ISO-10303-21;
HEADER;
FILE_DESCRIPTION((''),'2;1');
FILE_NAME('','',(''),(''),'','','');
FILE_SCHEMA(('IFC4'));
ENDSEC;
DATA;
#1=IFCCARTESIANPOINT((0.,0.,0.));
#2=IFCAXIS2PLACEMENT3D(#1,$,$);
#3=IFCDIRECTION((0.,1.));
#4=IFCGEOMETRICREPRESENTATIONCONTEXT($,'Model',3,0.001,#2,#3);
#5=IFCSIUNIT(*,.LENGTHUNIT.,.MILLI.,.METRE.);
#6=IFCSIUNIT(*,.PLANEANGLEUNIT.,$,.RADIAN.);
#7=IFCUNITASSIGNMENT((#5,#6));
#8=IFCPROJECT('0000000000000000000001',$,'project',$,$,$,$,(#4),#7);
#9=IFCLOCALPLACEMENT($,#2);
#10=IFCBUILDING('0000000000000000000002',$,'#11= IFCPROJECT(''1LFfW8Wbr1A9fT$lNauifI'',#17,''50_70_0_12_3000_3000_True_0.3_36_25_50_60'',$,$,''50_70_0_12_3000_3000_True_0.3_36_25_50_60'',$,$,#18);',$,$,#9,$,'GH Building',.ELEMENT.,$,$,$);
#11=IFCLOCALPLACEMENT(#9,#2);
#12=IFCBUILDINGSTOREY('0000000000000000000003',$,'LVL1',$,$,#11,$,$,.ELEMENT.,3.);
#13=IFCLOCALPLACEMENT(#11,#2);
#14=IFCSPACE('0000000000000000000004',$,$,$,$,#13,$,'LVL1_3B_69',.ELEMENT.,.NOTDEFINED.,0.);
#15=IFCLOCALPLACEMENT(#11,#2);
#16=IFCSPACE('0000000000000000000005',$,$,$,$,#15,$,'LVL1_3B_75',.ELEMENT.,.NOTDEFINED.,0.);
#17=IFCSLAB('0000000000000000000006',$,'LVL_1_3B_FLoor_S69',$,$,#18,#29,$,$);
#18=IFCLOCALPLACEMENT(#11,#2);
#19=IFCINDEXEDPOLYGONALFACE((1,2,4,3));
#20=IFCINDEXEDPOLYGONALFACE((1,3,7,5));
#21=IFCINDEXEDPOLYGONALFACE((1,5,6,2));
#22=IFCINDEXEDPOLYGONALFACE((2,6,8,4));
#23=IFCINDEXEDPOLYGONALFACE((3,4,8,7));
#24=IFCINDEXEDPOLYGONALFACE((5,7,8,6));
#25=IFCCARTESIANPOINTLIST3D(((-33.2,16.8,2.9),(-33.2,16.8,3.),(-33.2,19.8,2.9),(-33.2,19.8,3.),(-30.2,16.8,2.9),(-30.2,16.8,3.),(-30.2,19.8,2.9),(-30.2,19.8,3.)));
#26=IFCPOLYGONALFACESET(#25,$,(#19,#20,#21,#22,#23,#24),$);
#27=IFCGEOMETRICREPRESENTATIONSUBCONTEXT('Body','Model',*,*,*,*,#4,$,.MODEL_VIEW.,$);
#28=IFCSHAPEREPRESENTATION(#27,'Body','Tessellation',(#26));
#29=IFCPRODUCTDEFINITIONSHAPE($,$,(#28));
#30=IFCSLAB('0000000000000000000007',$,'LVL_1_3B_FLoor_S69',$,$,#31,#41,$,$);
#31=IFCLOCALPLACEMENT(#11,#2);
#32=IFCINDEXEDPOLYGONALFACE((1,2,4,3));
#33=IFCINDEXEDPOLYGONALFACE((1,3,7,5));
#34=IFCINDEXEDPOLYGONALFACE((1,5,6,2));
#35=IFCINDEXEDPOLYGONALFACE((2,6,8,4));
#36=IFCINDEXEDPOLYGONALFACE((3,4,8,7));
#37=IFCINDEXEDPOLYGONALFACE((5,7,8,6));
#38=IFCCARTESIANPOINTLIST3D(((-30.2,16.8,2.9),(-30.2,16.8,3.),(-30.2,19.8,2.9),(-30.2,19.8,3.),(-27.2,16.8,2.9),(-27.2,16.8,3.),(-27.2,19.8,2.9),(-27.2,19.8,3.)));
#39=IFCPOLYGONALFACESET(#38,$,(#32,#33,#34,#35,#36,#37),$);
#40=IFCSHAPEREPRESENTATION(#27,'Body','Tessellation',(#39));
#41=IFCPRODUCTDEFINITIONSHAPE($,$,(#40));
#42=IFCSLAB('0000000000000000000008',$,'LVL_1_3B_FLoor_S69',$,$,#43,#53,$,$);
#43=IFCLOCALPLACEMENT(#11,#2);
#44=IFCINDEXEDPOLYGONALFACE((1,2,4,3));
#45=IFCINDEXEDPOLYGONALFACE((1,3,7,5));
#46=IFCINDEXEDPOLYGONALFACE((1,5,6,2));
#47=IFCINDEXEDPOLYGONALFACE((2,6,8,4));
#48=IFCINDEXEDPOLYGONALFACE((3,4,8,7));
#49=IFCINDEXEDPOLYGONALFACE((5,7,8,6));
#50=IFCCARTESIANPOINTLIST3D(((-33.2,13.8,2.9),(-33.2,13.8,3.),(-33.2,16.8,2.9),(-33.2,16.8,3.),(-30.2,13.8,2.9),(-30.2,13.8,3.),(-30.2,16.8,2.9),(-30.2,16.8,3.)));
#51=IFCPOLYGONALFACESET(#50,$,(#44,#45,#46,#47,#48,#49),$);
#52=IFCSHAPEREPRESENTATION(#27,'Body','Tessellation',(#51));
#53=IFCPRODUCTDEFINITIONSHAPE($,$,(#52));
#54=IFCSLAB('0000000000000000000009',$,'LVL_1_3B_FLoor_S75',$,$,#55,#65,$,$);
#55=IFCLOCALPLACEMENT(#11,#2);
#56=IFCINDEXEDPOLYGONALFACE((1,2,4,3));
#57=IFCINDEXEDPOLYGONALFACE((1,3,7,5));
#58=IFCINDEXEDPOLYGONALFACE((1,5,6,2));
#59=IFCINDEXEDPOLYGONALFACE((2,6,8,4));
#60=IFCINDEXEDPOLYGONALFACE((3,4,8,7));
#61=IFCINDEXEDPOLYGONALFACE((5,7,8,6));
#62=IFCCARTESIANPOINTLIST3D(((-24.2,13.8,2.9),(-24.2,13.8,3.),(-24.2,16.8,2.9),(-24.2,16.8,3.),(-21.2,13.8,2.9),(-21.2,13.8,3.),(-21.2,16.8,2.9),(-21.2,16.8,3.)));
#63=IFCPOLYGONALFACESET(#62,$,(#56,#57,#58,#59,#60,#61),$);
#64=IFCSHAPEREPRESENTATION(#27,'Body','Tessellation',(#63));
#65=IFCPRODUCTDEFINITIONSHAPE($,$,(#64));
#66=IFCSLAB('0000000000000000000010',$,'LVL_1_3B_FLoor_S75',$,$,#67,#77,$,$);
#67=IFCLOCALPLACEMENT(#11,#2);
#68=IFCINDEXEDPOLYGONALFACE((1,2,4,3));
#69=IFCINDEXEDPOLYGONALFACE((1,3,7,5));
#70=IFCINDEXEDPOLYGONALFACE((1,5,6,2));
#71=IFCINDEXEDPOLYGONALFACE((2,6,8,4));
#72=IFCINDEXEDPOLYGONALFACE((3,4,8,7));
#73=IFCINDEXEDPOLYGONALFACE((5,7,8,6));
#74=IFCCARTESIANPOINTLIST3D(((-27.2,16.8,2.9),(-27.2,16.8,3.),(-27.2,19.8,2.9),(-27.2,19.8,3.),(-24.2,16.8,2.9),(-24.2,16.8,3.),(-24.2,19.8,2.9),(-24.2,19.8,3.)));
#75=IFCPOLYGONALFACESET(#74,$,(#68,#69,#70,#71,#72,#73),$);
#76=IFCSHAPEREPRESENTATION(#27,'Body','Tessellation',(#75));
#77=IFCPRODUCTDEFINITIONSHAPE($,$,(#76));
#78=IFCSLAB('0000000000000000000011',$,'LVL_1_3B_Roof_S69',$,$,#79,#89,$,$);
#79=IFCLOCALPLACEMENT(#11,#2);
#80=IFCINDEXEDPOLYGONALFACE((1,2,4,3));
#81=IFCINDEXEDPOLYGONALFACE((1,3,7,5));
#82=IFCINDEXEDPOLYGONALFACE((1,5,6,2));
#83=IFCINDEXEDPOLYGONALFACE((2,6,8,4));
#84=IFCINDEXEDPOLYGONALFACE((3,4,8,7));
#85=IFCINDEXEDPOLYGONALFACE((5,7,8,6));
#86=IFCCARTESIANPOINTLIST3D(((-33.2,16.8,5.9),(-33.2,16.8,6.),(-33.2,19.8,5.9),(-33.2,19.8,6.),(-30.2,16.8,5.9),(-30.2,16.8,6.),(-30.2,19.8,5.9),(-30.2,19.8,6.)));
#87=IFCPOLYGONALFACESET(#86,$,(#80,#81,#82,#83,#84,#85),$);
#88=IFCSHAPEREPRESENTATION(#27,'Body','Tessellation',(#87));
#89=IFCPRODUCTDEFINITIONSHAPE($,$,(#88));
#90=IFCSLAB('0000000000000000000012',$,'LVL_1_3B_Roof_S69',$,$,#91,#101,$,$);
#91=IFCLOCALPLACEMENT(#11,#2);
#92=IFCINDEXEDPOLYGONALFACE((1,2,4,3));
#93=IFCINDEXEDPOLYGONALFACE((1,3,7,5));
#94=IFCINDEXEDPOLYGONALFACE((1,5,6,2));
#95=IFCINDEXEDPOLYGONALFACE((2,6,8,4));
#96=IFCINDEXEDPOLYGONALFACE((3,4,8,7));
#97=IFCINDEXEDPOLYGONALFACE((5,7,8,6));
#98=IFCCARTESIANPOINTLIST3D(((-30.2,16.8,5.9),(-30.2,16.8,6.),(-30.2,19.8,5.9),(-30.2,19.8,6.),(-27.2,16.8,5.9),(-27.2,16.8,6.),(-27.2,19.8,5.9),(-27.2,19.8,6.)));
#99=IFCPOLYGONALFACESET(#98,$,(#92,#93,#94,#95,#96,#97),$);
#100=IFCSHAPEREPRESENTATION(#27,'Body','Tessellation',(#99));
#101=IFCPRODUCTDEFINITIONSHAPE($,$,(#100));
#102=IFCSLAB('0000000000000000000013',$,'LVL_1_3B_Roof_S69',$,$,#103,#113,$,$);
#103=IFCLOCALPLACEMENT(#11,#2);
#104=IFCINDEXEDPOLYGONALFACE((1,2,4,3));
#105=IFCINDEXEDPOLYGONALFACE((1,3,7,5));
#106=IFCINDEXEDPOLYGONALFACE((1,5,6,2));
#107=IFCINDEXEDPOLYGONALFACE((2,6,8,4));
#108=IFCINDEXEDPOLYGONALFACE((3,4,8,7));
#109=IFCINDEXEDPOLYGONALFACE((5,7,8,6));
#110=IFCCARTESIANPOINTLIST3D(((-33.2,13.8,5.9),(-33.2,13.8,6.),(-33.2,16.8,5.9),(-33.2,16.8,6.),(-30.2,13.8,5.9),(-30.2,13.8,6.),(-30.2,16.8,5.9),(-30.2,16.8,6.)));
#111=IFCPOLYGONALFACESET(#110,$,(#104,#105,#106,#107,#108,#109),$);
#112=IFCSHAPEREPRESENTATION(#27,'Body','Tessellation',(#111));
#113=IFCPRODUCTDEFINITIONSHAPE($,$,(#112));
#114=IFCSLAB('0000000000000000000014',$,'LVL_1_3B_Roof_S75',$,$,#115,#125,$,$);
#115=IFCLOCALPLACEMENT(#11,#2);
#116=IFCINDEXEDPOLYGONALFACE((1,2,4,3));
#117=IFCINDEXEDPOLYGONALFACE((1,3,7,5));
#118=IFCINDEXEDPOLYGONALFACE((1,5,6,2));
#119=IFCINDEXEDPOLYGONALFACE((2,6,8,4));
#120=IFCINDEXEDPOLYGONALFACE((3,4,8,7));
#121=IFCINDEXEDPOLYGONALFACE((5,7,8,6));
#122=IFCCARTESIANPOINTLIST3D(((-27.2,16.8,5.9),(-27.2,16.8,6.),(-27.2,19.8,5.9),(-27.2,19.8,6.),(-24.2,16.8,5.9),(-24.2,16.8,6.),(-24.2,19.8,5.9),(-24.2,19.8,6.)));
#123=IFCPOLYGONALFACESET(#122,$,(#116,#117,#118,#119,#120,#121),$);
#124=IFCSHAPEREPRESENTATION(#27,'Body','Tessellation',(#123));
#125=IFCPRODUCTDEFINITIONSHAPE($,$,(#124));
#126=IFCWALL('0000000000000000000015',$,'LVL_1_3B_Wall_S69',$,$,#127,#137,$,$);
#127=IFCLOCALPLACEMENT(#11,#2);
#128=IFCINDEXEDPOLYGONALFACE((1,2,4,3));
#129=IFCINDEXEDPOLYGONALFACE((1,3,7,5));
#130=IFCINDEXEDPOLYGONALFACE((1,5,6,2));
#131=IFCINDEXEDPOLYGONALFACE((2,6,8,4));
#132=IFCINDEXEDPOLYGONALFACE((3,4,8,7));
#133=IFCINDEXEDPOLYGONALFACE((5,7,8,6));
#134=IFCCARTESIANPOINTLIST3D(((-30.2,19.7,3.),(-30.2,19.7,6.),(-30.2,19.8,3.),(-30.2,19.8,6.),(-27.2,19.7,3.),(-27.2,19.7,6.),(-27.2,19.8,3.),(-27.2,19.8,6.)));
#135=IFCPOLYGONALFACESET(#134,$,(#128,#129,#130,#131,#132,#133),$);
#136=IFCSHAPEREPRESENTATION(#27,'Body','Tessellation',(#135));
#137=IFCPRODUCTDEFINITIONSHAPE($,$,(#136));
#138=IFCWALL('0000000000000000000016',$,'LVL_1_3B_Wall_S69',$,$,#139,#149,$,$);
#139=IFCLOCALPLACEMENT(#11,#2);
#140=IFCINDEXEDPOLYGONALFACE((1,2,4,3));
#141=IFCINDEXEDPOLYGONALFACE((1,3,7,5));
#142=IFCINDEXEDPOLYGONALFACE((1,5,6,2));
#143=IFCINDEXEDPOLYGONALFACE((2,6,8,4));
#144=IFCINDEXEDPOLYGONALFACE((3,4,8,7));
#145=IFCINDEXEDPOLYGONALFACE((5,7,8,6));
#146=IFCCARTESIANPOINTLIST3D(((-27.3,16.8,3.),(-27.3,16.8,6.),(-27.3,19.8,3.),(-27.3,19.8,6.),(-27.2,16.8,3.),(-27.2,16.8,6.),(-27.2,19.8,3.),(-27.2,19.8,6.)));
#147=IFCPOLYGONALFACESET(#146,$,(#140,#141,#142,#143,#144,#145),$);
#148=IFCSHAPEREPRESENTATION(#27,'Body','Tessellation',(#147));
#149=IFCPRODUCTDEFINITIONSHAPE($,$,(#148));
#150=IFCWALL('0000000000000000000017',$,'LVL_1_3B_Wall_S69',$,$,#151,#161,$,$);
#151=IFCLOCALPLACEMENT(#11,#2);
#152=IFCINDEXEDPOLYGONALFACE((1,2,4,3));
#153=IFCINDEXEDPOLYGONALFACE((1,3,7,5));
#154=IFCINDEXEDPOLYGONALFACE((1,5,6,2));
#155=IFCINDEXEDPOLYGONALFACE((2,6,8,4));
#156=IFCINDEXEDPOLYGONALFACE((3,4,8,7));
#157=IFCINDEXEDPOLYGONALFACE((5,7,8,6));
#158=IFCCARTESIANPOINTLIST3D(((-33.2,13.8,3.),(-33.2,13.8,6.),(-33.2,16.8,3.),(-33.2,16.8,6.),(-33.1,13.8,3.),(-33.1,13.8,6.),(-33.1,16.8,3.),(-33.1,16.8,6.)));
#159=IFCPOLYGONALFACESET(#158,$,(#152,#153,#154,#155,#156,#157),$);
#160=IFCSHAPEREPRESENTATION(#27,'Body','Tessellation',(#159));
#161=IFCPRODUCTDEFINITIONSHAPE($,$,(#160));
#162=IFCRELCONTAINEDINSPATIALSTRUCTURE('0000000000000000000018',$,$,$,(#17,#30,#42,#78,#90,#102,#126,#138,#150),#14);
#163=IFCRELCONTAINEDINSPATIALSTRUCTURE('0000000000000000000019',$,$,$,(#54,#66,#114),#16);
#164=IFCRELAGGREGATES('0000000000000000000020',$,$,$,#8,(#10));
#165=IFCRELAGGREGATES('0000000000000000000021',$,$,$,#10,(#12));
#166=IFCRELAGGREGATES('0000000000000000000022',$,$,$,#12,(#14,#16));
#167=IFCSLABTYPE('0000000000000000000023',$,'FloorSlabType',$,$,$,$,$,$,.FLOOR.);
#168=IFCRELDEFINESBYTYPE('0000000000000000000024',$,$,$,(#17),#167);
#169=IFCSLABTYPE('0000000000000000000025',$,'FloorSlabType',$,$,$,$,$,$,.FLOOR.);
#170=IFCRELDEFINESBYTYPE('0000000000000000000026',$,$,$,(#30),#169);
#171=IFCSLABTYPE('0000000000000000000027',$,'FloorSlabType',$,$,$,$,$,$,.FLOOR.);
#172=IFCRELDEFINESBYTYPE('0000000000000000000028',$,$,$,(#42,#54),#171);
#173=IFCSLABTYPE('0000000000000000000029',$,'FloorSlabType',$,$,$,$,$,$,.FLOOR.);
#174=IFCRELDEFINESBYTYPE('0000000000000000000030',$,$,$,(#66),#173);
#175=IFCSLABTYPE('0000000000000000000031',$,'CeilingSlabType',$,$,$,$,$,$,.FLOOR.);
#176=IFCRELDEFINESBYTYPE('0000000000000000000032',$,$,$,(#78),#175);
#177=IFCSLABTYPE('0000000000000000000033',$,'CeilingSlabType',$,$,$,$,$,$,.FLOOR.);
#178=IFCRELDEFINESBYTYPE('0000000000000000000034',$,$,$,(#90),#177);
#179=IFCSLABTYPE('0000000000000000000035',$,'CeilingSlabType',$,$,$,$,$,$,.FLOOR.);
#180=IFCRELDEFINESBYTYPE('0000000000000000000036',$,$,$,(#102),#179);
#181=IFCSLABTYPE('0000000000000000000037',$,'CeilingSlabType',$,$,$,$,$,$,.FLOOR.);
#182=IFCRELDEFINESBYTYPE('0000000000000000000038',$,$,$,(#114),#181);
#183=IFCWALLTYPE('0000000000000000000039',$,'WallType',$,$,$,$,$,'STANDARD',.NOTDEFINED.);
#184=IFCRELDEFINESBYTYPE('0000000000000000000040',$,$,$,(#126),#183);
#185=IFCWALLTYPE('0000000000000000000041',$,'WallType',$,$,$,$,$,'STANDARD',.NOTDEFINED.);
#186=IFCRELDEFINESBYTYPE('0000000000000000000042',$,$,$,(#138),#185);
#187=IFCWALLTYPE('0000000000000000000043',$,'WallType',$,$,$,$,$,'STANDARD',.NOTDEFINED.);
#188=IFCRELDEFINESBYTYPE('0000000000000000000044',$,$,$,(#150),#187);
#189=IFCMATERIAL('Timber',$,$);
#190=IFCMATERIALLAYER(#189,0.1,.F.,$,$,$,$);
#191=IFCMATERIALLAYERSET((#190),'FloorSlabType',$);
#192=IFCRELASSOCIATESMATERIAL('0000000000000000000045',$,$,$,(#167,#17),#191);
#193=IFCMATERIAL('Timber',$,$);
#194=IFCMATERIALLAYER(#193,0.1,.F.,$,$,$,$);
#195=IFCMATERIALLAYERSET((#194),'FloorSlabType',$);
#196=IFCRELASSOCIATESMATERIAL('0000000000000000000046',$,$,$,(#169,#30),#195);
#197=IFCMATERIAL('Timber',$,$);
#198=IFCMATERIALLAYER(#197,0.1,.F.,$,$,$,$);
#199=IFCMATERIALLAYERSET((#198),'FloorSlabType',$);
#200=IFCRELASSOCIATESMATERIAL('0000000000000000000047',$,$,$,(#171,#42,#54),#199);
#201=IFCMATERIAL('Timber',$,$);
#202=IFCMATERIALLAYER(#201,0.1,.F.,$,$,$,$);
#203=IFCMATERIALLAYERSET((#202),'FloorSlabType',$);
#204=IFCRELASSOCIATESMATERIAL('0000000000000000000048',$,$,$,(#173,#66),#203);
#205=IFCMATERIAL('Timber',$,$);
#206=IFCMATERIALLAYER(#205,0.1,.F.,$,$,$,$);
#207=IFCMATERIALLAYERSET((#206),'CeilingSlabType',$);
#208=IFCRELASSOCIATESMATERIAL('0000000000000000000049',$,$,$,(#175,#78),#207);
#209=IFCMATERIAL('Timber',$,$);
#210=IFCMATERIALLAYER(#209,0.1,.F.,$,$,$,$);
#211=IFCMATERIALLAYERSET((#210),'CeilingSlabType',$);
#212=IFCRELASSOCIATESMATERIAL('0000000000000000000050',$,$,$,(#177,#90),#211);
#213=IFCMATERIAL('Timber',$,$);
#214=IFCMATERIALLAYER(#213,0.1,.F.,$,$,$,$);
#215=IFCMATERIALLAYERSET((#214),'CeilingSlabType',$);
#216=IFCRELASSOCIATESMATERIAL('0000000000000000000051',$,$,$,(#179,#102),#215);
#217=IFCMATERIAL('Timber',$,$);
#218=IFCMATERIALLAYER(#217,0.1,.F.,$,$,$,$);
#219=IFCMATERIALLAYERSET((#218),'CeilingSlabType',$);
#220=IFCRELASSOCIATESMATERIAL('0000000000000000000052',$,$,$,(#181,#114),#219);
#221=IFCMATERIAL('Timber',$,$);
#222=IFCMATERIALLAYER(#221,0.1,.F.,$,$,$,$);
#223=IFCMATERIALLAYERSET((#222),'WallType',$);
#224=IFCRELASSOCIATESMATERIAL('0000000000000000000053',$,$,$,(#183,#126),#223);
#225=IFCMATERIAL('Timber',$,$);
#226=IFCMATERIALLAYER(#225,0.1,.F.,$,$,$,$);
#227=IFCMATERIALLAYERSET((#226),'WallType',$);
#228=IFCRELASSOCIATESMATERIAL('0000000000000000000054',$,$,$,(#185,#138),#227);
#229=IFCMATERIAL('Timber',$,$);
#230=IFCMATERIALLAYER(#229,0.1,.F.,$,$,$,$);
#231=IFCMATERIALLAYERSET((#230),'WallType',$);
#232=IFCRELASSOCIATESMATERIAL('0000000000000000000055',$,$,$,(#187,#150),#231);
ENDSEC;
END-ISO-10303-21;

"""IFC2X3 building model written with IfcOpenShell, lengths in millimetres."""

from ifc_helpers import new_model, si_unit, direction, frame, frame_2d, origin, place, context, subcontext, project, spatial, rectangle, extrude, material, layer, layer_set, layer_usage, type_object, element, save


model = new_model("IFC2X3")

# Units and contexts
model_context = context("Model", 3, precision=0.001, world=origin(), true_north=direction((0.0, 1.0)))
body_context = subcontext(model_context, "Body", "Model", "MODEL_VIEW")
ifc_project = project(units=[si_unit("LENGTHUNIT", "METRE", prefix="MILLI"), si_unit("PLANEANGLEUNIT", "RADIAN")], contexts=[model_context])

# Building, storey
building_placement = place(None, origin())
building = spatial("IfcBuilding", under=ifc_project, at=building_placement, Name="#11= IFCPROJECT('1LFfW8Wbr1A9fT$lNauifI',#17,'50_70_0_12_3000_3000_True_0.3_36_25_50_60',$,$,'50_70_0_12_3000_3000_True_0.3_36_25_50_60',$,$,#18);", LongName="GH Building", CompositionType="ELEMENT")
storey_placement = place(building_placement, origin())
storey = spatial("IfcBuildingStorey", under=building, at=storey_placement, Name="LVL1", CompositionType="ELEMENT", Elevation=3.0)

# Shared definitions
space_1_placement = place(storey_placement, origin())
space_1 = spatial("IfcSpace", under=storey, at=space_1_placement, LongName="LVL1_3B_69", CompositionType="ELEMENT", InteriorOrExteriorSpace="NOTDEFINED", ElevationWithFlooring=0.0)

# Slabs
ifc_material_1 = material(Name="Timber")
ifc_layer_1 = layer(ifc_material_1, 0.1, ventilated=False)
ifc_layer_set_1 = layer_set([ifc_layer_1], Name="FloorSlabType")
ifc_layer_usage_1 = layer_usage(ifc_layer_set_1, "AXIS3", "NEGATIVE", -0.1)
slab_type_1 = type_object("IfcSlabType", Name="FloorSlabType", PredefinedType="FLOOR", material=ifc_layer_set_1)
slab_1_placement = place(space_1_placement, frame((-33.2, 16.8, 2.9)))
element("IfcSlab", 1, at=slab_1_placement, inside=space_1, type_object=slab_type_1, material=ifc_layer_usage_1, Name="LVL_1_3B_FLoor_S69", context=body_context, shape_type="SweptSolid", body=[
    extrude(rectangle(XDim=3.0, YDim=3.0, at=frame_2d((1.5, 1.5))), origin(), (0.0, 0.0, 1.0), 0.1),
])
ifc_material_2 = material(Name="Timber")
ifc_layer_2 = layer(ifc_material_2, 0.1, ventilated=False)
ifc_layer_set_2 = layer_set([ifc_layer_2], Name="FloorSlabType")
ifc_layer_usage_2 = layer_usage(ifc_layer_set_2, "AXIS3", "NEGATIVE", -0.1)
slab_type_2 = type_object("IfcSlabType", Name="FloorSlabType", PredefinedType="FLOOR", material=ifc_layer_set_2)
slab_2_placement = place(space_1_placement, frame((-30.2, 16.8, 2.9)))
element("IfcSlab", 2, at=slab_2_placement, inside=space_1, type_object=slab_type_2, material=ifc_layer_usage_2, Name="LVL_1_3B_FLoor_S69", context=body_context, shape_type="SweptSolid", body=[
    extrude(rectangle(XDim=3.0, YDim=3.0, at=frame_2d((1.5, 1.5))), origin(), (0.0, 0.0, 1.0), 0.1),
])
ifc_material_3 = material(Name="Timber")
ifc_layer_3 = layer(ifc_material_3, 0.1, ventilated=False)
ifc_layer_set_3 = layer_set([ifc_layer_3], Name="FloorSlabType")
ifc_layer_usage_3 = layer_usage(ifc_layer_set_3, "AXIS3", "NEGATIVE", -0.1)
slab_type_3 = type_object("IfcSlabType", Name="FloorSlabType", PredefinedType="FLOOR", material=ifc_layer_set_3)
slab_3_placement = place(space_1_placement, frame((-33.2, 13.8, 2.9)))
element("IfcSlab", 3, at=slab_3_placement, inside=space_1, type_object=slab_type_3, material=ifc_layer_usage_3, Name="LVL_1_3B_FLoor_S69", context=body_context, shape_type="SweptSolid", body=[
    extrude(rectangle(XDim=3.0, YDim=3.0, at=frame_2d((1.5, 1.5))), origin(), (0.0, 0.0, 1.0), 0.1),
])

# Shared definitions
space_2_placement = place(storey_placement, origin())
space_2 = spatial("IfcSpace", under=storey, at=space_2_placement, LongName="LVL1_3B_75", CompositionType="ELEMENT", InteriorOrExteriorSpace="NOTDEFINED", ElevationWithFlooring=0.0)

# Slabs
ifc_layer_usage_4 = layer_usage(ifc_layer_set_3, "AXIS3", "NEGATIVE", -0.1)
slab_4_placement = place(space_2_placement, frame((-24.2, 13.8, 2.9)))
element("IfcSlab", 4, at=slab_4_placement, inside=space_2, type_object=slab_type_3, material=ifc_layer_usage_4, Name="LVL_1_3B_FLoor_S75", context=body_context, shape_type="SweptSolid", body=[
    extrude(rectangle(XDim=3.0, YDim=3.0, at=frame_2d((1.5, 1.5))), origin(), (0.0, 0.0, 1.0), 0.1),
])
ifc_material_4 = material(Name="Timber")
ifc_layer_4 = layer(ifc_material_4, 0.1, ventilated=False)
ifc_layer_set_4 = layer_set([ifc_layer_4], Name="FloorSlabType")
ifc_layer_usage_5 = layer_usage(ifc_layer_set_4, "AXIS3", "NEGATIVE", -0.1)
slab_type_4 = type_object("IfcSlabType", Name="FloorSlabType", PredefinedType="FLOOR", material=ifc_layer_set_4)
slab_5_placement = place(space_2_placement, frame((-27.2, 16.8, 2.9)))
element("IfcSlab", 5, at=slab_5_placement, inside=space_2, type_object=slab_type_4, material=ifc_layer_usage_5, Name="LVL_1_3B_FLoor_S75", context=body_context, shape_type="SweptSolid", body=[
    extrude(rectangle(XDim=3.0, YDim=3.0, at=frame_2d((1.5, 1.5))), origin(), (0.0, 0.0, 1.0), 0.1),
])
ifc_material_5 = material(Name="Timber")
ifc_layer_5 = layer(ifc_material_5, 0.1, ventilated=False)
ifc_layer_set_5 = layer_set([ifc_layer_5], Name="CeilingSlabType")
ifc_layer_usage_6 = layer_usage(ifc_layer_set_5, "AXIS3", "NEGATIVE", -0.1)
slab_type_5 = type_object("IfcSlabType", Name="CeilingSlabType", PredefinedType="FLOOR", material=ifc_layer_set_5)
slab_6_placement = place(space_1_placement, frame((-33.2, 16.8, 5.9)))
element("IfcSlab", 6, at=slab_6_placement, inside=space_1, type_object=slab_type_5, material=ifc_layer_usage_6, Name="LVL_1_3B_Roof_S69", context=body_context, shape_type="SweptSolid", body=[
    extrude(rectangle(XDim=3.0, YDim=3.0, at=frame_2d((1.5, 1.5))), origin(), (0.0, 0.0, 1.0), 0.1),
])
ifc_material_6 = material(Name="Timber")
ifc_layer_6 = layer(ifc_material_6, 0.1, ventilated=False)
ifc_layer_set_6 = layer_set([ifc_layer_6], Name="CeilingSlabType")
ifc_layer_usage_7 = layer_usage(ifc_layer_set_6, "AXIS3", "NEGATIVE", -0.1)
slab_type_6 = type_object("IfcSlabType", Name="CeilingSlabType", PredefinedType="FLOOR", material=ifc_layer_set_6)
slab_7_placement = place(space_1_placement, frame((-30.2, 16.8, 5.9)))
element("IfcSlab", 7, at=slab_7_placement, inside=space_1, type_object=slab_type_6, material=ifc_layer_usage_7, Name="LVL_1_3B_Roof_S69", context=body_context, shape_type="SweptSolid", body=[
    extrude(rectangle(XDim=3.0, YDim=3.0, at=frame_2d((1.5, 1.5))), origin(), (0.0, 0.0, 1.0), 0.1),
])
ifc_material_7 = material(Name="Timber")
ifc_layer_7 = layer(ifc_material_7, 0.1, ventilated=False)
ifc_layer_set_7 = layer_set([ifc_layer_7], Name="CeilingSlabType")
ifc_layer_usage_8 = layer_usage(ifc_layer_set_7, "AXIS3", "NEGATIVE", -0.1)
slab_type_7 = type_object("IfcSlabType", Name="CeilingSlabType", PredefinedType="FLOOR", material=ifc_layer_set_7)
slab_8_placement = place(space_1_placement, frame((-33.2, 13.8, 5.9)))
element("IfcSlab", 8, at=slab_8_placement, inside=space_1, type_object=slab_type_7, material=ifc_layer_usage_8, Name="LVL_1_3B_Roof_S69", context=body_context, shape_type="SweptSolid", body=[
    extrude(rectangle(XDim=3.0, YDim=3.0, at=frame_2d((1.5, 1.5))), origin(), (0.0, 0.0, 1.0), 0.1),
])
ifc_material_8 = material(Name="Timber")
ifc_layer_8 = layer(ifc_material_8, 0.1, ventilated=False)
ifc_layer_set_8 = layer_set([ifc_layer_8], Name="CeilingSlabType")
ifc_layer_usage_9 = layer_usage(ifc_layer_set_8, "AXIS3", "NEGATIVE", -0.1)
slab_type_8 = type_object("IfcSlabType", Name="CeilingSlabType", PredefinedType="FLOOR", material=ifc_layer_set_8)
slab_9_placement = place(space_2_placement, frame((-27.2, 16.8, 5.9)))
element("IfcSlab", 9, at=slab_9_placement, inside=space_2, type_object=slab_type_8, material=ifc_layer_usage_9, Name="LVL_1_3B_Roof_S75", context=body_context, shape_type="SweptSolid", body=[
    extrude(rectangle(XDim=3.0, YDim=3.0, at=frame_2d((1.5, 1.5))), origin(), (0.0, 0.0, 1.0), 0.1),
])

# Walls
ifc_material_9 = material(Name="Timber")
ifc_layer_9 = layer(ifc_material_9, 0.1, ventilated=False)
ifc_layer_set_9 = layer_set([ifc_layer_9], Name="WallType")
ifc_layer_usage_10 = layer_usage(ifc_layer_set_9, "AXIS2", "NEGATIVE", 0.0)
wall_type_1 = type_object("IfcWallType", Name="WallType", ElementType="STANDARD", PredefinedType="NOTDEFINED", material=ifc_layer_set_9)
wall_1_placement = place(space_1_placement, frame((-30.2, 19.8, 3.0)))
element("IfcWall", 10, at=wall_1_placement, inside=space_1, type_object=wall_type_1, material=ifc_layer_usage_10, Name="LVL_1_3B_Wall_S69", context=body_context, shape_type="SweptSolid", body=[
    extrude(rectangle(XDim=3.0, YDim=0.1, at=frame_2d((1.5, -0.1))), origin(), (0.0, 0.0, 1.0), 3.0),
])
ifc_material_10 = material(Name="Timber")
ifc_layer_10 = layer(ifc_material_10, 0.1, ventilated=False)
ifc_layer_set_10 = layer_set([ifc_layer_10], Name="WallType")
ifc_layer_usage_11 = layer_usage(ifc_layer_set_10, "AXIS2", "NEGATIVE", 0.0)
wall_type_2 = type_object("IfcWallType", Name="WallType", ElementType="STANDARD", PredefinedType="NOTDEFINED", material=ifc_layer_set_10)
wall_2_placement = place(space_1_placement, frame((-27.2, 19.8, 3.0), z_axis=(0.0, 0.0, 1.0), x_axis=(0.0, -1.0, 0.0)))
element("IfcWall", 11, at=wall_2_placement, inside=space_1, type_object=wall_type_2, material=ifc_layer_usage_11, Name="LVL_1_3B_Wall_S69", context=body_context, shape_type="SweptSolid", body=[
    extrude(rectangle(XDim=3.0, YDim=0.1, at=frame_2d((1.5, -0.1))), origin(), (0.0, 0.0, 1.0), 3.0),
])
ifc_material_11 = material(Name="Timber")
ifc_layer_11 = layer(ifc_material_11, 0.1, ventilated=False)
ifc_layer_set_11 = layer_set([ifc_layer_11], Name="WallType")
ifc_layer_usage_12 = layer_usage(ifc_layer_set_11, "AXIS2", "NEGATIVE", 0.0)
wall_type_3 = type_object("IfcWallType", Name="WallType", ElementType="STANDARD", PredefinedType="NOTDEFINED", material=ifc_layer_set_11)
wall_3_placement = place(space_1_placement, frame((-33.2, 13.8, 3.0), z_axis=(0.0, 0.0, 1.0), x_axis=(0.0, 1.0, 0.0)))
element("IfcWall", 12, at=wall_3_placement, inside=space_1, type_object=wall_type_3, material=ifc_layer_usage_12, Name="LVL_1_3B_Wall_S69", context=body_context, shape_type="SweptSolid", body=[
    extrude(rectangle(XDim=3.0, YDim=0.1, at=frame_2d((1.5, -0.1))), origin(), (0.0, 0.0, 1.0), 3.0),
])

save(model, "model.ifc")
